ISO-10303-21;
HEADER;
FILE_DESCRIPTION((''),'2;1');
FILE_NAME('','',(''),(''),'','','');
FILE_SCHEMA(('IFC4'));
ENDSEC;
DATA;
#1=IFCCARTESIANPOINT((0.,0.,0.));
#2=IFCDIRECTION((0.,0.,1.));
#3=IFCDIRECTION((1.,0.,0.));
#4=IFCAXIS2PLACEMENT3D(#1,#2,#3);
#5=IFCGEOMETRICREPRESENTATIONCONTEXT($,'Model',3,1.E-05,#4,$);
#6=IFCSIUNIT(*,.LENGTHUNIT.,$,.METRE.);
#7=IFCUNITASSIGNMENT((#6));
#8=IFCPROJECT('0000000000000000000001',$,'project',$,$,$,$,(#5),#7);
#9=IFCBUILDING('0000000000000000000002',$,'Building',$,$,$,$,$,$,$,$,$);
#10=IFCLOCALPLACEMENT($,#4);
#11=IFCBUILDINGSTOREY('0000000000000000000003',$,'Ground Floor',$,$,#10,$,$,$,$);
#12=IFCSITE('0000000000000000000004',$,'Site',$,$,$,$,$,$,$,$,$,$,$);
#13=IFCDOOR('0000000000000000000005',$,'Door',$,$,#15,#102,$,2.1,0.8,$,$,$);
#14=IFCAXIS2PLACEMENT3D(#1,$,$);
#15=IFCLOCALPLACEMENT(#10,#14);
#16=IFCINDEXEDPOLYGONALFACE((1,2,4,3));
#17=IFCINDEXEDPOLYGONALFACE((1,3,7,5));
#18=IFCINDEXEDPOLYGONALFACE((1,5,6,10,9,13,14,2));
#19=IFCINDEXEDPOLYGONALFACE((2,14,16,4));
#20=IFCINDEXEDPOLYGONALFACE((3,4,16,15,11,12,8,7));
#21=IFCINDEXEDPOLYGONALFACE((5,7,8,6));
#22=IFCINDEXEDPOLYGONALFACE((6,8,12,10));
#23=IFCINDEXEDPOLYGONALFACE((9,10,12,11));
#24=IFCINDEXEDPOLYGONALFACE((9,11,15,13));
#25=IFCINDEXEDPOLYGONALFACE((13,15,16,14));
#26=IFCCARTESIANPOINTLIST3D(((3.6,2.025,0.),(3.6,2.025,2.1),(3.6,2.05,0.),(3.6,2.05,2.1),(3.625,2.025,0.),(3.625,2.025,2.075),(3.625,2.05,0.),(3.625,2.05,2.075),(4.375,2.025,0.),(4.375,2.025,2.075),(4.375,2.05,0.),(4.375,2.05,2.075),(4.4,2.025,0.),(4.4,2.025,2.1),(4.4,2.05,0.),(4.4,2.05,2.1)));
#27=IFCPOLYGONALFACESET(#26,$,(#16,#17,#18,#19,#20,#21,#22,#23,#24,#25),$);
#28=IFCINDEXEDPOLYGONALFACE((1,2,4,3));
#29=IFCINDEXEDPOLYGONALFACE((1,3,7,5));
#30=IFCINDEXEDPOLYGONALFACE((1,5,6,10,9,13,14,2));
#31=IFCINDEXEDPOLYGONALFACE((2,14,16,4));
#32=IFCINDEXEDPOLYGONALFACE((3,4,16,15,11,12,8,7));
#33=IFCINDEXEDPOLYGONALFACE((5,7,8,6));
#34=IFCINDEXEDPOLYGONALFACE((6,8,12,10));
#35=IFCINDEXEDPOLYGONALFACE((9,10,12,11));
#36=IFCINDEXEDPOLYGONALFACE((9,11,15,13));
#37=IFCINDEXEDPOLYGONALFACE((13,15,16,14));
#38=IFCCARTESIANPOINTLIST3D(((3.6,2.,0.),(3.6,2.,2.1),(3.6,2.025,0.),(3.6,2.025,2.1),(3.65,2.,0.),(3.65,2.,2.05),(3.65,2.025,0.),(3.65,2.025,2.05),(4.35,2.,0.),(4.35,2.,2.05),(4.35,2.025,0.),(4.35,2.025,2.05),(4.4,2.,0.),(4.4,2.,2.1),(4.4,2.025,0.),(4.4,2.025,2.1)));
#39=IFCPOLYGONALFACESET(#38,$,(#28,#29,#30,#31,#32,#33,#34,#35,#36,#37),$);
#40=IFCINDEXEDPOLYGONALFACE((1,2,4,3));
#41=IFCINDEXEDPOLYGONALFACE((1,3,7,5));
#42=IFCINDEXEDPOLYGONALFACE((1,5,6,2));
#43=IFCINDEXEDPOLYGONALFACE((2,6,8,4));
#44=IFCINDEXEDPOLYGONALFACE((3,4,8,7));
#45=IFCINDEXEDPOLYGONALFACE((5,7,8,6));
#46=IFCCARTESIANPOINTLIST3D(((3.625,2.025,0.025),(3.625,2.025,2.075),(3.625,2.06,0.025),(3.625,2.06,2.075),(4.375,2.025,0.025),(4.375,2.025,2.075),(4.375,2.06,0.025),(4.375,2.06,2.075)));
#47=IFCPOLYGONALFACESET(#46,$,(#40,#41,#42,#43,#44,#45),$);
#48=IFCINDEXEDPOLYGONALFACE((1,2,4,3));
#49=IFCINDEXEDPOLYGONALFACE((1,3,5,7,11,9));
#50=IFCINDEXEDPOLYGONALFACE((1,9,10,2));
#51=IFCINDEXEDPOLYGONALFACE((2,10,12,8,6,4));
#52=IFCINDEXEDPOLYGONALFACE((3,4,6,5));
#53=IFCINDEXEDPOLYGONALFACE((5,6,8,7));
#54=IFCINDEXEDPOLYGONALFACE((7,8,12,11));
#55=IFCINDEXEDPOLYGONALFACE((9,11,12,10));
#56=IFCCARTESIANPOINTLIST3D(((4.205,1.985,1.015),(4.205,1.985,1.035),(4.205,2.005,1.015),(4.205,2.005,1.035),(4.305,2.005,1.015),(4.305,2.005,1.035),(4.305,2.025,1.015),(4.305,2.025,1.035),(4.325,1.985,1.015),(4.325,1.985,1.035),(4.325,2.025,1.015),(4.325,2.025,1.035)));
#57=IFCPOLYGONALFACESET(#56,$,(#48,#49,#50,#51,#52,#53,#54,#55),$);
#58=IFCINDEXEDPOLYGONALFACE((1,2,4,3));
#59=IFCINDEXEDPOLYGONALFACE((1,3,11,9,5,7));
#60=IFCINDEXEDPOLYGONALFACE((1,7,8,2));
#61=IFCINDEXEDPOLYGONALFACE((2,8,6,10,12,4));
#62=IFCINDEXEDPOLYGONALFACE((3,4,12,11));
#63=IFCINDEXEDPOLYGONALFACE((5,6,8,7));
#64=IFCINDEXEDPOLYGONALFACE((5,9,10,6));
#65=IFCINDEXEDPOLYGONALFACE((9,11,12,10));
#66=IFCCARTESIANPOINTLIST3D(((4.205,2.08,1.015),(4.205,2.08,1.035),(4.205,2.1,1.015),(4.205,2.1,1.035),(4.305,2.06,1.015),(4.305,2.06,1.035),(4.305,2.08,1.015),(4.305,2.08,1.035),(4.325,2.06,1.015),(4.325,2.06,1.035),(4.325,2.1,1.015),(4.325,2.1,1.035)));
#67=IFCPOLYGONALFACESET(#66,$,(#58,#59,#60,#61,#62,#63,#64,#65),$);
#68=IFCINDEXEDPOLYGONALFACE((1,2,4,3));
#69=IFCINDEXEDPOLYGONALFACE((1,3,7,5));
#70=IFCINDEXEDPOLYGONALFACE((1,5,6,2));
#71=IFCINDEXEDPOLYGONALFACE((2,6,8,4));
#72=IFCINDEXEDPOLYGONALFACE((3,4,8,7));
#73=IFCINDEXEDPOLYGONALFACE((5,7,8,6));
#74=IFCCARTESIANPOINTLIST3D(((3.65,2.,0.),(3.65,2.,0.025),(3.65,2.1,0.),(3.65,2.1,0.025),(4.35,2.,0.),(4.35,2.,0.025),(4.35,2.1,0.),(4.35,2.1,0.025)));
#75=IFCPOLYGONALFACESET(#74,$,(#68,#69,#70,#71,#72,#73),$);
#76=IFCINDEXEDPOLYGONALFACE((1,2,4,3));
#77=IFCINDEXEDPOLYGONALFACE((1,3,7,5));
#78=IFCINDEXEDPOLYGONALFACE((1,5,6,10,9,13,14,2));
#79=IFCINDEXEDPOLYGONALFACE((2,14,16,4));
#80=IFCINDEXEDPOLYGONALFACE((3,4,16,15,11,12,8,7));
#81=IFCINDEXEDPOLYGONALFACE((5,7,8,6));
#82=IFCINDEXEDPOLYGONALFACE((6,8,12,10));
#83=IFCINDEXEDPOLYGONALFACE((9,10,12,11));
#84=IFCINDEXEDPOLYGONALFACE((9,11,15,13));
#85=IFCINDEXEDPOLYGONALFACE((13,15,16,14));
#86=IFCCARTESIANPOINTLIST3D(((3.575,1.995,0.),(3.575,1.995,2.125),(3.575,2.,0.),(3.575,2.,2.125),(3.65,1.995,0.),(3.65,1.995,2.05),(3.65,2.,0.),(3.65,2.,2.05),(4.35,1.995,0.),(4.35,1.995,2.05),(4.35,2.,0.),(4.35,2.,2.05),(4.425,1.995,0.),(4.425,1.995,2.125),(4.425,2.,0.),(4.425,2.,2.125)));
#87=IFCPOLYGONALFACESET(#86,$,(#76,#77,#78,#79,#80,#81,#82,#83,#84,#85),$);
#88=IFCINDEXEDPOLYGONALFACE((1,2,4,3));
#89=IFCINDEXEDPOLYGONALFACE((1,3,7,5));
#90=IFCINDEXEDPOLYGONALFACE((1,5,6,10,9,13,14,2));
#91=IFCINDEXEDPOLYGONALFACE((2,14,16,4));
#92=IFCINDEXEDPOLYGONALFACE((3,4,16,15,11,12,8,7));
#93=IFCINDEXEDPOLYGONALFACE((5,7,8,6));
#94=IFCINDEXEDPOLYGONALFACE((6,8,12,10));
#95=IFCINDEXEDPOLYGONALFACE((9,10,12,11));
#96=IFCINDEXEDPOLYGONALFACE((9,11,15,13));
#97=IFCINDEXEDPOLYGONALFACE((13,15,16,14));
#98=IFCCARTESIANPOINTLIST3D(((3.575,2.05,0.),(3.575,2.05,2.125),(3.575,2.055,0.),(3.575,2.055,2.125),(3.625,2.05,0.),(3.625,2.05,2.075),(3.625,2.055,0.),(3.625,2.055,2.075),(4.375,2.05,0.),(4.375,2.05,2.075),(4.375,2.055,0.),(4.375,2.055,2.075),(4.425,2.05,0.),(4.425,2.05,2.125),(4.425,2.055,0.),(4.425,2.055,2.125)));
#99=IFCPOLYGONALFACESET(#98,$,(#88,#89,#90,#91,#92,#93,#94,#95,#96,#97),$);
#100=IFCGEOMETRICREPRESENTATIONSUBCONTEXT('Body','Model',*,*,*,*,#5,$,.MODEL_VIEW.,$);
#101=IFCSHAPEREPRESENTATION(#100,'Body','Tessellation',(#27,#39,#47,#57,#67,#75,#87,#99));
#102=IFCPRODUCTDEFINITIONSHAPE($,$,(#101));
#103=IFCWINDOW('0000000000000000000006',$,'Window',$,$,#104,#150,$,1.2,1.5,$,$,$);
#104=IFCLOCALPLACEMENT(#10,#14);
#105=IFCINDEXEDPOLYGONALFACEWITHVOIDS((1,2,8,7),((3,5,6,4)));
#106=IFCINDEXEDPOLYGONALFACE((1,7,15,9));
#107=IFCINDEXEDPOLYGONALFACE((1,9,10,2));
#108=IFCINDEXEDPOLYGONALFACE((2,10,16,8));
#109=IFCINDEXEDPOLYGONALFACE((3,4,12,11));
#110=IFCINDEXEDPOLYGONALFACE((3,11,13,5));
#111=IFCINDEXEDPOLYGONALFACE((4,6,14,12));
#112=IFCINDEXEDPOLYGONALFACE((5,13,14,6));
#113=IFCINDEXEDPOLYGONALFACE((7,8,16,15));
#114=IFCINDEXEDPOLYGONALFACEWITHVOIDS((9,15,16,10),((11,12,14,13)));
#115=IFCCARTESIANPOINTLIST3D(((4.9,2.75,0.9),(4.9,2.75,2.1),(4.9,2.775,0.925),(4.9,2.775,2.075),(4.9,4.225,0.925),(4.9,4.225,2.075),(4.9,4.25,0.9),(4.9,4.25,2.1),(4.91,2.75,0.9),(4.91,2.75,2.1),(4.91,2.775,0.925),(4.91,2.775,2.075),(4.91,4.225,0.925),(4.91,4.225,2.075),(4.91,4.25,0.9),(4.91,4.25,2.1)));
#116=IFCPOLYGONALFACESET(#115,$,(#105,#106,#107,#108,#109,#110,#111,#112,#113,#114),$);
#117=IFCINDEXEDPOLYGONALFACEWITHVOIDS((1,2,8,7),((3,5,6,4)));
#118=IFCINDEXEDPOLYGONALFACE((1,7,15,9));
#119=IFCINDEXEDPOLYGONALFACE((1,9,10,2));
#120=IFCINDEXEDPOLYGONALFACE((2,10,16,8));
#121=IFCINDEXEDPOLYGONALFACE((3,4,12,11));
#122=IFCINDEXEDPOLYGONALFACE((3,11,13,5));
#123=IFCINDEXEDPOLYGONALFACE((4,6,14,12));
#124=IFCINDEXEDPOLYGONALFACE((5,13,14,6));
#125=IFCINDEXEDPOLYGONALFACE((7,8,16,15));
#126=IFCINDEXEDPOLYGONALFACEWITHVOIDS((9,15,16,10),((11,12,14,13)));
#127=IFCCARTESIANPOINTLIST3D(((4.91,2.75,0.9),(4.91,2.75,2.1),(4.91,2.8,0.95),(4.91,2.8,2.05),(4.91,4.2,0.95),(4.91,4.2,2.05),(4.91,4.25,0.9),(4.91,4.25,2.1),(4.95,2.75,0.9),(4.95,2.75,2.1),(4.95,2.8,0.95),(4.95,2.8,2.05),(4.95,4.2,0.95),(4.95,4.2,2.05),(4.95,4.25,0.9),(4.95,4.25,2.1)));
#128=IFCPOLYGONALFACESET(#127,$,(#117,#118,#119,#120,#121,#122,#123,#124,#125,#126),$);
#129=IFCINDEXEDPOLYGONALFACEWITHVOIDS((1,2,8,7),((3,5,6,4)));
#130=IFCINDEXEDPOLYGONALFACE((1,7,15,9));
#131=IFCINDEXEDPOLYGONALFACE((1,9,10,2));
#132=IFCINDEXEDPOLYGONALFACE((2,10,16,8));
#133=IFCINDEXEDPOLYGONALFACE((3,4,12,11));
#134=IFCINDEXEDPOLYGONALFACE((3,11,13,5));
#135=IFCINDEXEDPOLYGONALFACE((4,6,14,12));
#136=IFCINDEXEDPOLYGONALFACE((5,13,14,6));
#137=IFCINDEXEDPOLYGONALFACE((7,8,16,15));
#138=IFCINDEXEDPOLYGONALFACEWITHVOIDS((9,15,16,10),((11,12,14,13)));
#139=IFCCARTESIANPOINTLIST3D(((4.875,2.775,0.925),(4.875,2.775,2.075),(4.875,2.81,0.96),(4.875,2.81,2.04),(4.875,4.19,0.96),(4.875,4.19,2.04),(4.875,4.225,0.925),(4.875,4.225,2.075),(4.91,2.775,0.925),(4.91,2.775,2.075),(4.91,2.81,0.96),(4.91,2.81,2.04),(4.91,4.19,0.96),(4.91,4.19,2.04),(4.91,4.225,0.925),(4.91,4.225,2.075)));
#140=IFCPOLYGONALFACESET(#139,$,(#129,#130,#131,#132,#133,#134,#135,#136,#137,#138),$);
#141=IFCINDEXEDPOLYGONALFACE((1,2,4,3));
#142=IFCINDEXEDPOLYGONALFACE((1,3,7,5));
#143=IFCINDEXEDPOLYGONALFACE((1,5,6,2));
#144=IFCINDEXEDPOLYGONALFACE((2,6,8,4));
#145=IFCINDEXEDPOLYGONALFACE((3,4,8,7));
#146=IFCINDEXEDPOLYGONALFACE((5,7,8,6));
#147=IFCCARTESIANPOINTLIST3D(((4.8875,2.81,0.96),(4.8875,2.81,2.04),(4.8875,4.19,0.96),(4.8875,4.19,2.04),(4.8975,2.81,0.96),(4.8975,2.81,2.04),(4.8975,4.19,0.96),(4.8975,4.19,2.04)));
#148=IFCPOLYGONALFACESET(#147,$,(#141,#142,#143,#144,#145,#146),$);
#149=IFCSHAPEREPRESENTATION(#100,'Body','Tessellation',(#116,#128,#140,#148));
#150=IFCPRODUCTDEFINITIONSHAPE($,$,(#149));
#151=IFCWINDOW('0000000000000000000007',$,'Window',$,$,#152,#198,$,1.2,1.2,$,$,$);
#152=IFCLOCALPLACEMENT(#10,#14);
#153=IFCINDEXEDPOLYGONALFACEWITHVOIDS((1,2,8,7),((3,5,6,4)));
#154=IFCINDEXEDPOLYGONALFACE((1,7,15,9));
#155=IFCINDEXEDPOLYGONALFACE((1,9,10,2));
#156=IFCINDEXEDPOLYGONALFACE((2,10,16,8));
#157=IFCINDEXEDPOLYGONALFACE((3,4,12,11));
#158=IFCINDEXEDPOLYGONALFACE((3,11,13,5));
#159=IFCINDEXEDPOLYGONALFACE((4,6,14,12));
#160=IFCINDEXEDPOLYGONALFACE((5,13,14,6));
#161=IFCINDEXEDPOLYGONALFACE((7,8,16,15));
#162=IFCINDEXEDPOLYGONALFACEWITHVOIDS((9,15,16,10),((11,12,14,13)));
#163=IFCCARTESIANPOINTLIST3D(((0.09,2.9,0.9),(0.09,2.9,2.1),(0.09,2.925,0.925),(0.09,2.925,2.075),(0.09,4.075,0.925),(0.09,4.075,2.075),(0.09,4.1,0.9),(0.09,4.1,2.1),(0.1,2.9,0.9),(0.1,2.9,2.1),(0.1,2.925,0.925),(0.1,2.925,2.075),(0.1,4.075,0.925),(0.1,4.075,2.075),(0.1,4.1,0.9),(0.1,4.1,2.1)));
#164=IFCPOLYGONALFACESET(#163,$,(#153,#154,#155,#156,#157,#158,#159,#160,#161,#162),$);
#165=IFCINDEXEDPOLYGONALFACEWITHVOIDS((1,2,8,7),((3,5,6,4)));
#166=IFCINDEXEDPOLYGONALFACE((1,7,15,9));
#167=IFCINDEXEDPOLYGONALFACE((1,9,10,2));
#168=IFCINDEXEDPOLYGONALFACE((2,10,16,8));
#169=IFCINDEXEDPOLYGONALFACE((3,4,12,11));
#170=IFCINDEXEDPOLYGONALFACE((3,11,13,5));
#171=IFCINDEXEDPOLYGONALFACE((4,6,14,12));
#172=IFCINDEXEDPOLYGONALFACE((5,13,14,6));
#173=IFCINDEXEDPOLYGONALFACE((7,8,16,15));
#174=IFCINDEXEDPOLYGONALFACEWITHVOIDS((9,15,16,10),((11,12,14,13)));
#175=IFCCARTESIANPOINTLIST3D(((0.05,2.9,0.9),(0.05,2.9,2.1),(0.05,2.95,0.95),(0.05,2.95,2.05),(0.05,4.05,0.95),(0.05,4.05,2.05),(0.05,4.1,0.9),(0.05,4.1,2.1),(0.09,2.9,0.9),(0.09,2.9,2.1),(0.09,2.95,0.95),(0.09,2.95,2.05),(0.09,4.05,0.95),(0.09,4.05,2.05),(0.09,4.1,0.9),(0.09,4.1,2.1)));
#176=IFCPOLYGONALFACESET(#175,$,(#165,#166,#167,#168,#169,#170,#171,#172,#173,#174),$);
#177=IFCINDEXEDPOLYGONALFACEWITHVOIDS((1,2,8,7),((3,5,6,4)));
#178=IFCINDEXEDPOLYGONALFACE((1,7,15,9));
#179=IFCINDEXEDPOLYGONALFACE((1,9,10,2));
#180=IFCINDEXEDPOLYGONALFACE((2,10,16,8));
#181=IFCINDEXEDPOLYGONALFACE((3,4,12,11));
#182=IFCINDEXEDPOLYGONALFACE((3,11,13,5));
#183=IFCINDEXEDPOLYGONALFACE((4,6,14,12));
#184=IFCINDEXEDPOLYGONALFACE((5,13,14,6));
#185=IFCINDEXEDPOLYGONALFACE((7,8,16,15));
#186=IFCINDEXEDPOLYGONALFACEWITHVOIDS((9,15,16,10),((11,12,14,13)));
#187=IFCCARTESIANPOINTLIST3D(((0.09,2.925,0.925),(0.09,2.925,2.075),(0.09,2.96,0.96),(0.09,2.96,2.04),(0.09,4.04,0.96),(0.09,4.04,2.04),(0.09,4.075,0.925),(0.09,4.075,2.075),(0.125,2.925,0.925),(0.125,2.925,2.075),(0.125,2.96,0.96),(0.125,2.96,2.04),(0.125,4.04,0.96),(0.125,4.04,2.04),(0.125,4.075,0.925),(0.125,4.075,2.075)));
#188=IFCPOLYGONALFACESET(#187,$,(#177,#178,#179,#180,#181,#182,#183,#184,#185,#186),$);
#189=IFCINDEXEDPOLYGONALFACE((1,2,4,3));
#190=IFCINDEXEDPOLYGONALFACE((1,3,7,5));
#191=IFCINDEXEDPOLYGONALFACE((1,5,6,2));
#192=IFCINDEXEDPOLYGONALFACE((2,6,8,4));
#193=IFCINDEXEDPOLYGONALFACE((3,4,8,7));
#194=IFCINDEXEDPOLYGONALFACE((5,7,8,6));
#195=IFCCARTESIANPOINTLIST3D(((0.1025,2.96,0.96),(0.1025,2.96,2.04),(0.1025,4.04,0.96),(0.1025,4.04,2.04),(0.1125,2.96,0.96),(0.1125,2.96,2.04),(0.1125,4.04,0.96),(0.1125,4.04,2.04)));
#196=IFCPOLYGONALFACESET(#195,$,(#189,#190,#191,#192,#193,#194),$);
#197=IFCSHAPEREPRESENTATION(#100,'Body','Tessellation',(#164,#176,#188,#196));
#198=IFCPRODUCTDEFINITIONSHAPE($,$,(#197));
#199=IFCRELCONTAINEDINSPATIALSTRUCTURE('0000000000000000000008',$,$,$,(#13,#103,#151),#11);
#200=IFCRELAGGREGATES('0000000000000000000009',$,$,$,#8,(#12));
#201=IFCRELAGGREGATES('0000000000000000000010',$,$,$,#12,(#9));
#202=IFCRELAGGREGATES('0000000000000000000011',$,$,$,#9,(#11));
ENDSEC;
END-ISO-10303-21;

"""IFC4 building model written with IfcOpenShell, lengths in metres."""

from ifc_helpers import new_model, si_unit, frame, origin_with_axes, place, context, subcontext, project, spatial, line, indexed_curve, outline, extrude, element, save


model = new_model("IFC4")

# Units and contexts
model_context = context("Model", 3, precision=1e-05, world=origin_with_axes())
body_context = subcontext(model_context, "Body", "Model", "MODEL_VIEW")
ifc_project = project(units=[si_unit("LENGTHUNIT", "METRE")], contexts=[model_context])

# Site, building, storey
site = spatial("IfcSite", under=ifc_project, Name="Site")
building = spatial("IfcBuilding", under=site, Name="Building")
storey_placement = place(None, origin_with_axes())
storey = spatial("IfcBuildingStorey", under=building, at=storey_placement, Name="Ground Floor")

# Door
door_1_placement = place(storey_placement, frame((3.6, 2.0, 0.0), z_axis=(0.0, 0.0, 1.0), x_axis=(1.0, 0.0, 0.0)))
element("IfcDoor", 1, at=door_1_placement, inside=storey, Name="Door", OverallHeight=2.1, OverallWidth=0.8, context=body_context, shape_type="SweptSolid", body=[
    extrude(outline(indexed_curve([(0.0, 0.0), (0.0, 2.1), (0.8, 2.1), (0.8, 0.0), (0.775, 0.0), (0.775, 2.075), (0.025, 2.075), (0.025, 0.0)], segments=[line(1, 2, 3, 4, 5, 6, 7, 8, 1)])), frame((0.0, 0.025, 0.0), z_axis=(0.0, -1.0, 0.0), x_axis=(1.0, 0.0, 0.0)), (0.0, 0.0, -1.0), 0.025),
    extrude(outline(indexed_curve([(0.0, 0.0), (0.0, 2.1), (0.8, 2.1), (0.8, 0.0), (0.75, 0.0), (0.75, 2.05), (0.05, 2.05), (0.05, 0.0)], segments=[line(1, 2, 3, 4, 5, 6, 7, 8, 1)])), frame((0.0, 0.0, 0.0), z_axis=(0.0, -1.0, 0.0), x_axis=(1.0, 0.0, 0.0)), (0.0, 0.0, -1.0), 0.025),
    extrude(outline(indexed_curve([(0.0, 0.0), (0.75, 0.0), (0.75, 0.035), (0.0, 0.035)], segments=[line(1, 2, 3, 4, 1)])), frame((0.025, 0.025, 0.025), z_axis=(0.0, 0.0, 1.0), x_axis=(1.0, 0.0, 0.0)), (0.0, 0.0, 1.0), 2.05),
    extrude(outline(indexed_curve([(0.0, 0.0), (0.0, -0.04), (-0.12, -0.04), (-0.12, -0.02), (-0.02, -0.02), (-0.02, 0.0)], segments=[line(1, 2, 3, 4, 5, 6, 1)])), frame((0.725, 0.025, 1.015), z_axis=(0.0, 0.0, 1.0), x_axis=(1.0, 0.0, 0.0)), (0.0, 0.0, 1.0), 0.02),
    extrude(outline(indexed_curve([(0.0, 0.0), (0.0, 0.04), (-0.12, 0.04), (-0.12, 0.02), (-0.02, 0.02), (-0.02, 0.0)], segments=[line(1, 2, 3, 4, 5, 6, 1)])), frame((0.725, 0.06, 1.015), z_axis=(0.0, 0.0, 1.0), x_axis=(1.0, 0.0, 0.0)), (0.0, 0.0, 1.0), 0.02),
    extrude(outline(indexed_curve([(0.0, 0.0), (0.7, 0.0), (0.7, 0.1), (0.0, 0.1)], segments=[line(1, 2, 3, 4, 1)])), frame((0.05, 0.0, 0.0), z_axis=(0.0, 0.0, 1.0), x_axis=(1.0, 0.0, 0.0)), (0.0, 0.0, 1.0), 0.025),
    extrude(outline(indexed_curve([(0.0, 0.0), (0.0, 2.125), (0.85, 2.125), (0.85, 0.0), (0.775, 0.0), (0.775, 2.05), (0.075, 2.05), (0.075, 0.0)], segments=[line(1, 2, 3, 4, 5, 6, 7, 8, 1)])), frame((-0.025, -0.005, 0.0), z_axis=(0.0, -1.0, 0.0), x_axis=(1.0, 0.0, 0.0)), (0.0, 0.0, -1.0), 0.005),
    extrude(outline(indexed_curve([(0.0, 0.0), (0.0, 2.125), (0.85, 2.125), (0.85, 0.0), (0.8, 0.0), (0.8, 2.075), (0.05, 2.075), (0.05, 0.0)], segments=[line(1, 2, 3, 4, 5, 6, 7, 8, 1)])), frame((-0.025, 0.05, 0.0), z_axis=(0.0, -1.0, 0.0), x_axis=(1.0, 0.0, 0.0)), (0.0, 0.0, -1.0), 0.005),
])

# Windows
window_1_placement = place(storey_placement, frame((5.0, 2.75, 0.9), z_axis=(0.0, 0.0, 1.0), x_axis=(0.0, 1.0, 0.0)))
element("IfcWindow", 2, at=window_1_placement, inside=storey, Name="Window", OverallHeight=1.2, OverallWidth=1.5, context=body_context, shape_type="SweptSolid", body=[
    extrude(outline(indexed_curve([(0.0, 0.0), (1.5, 0.0), (1.5, 1.2), (0.0, 1.2)], segments=[line(1, 2, 3, 4, 1)]), holes=[indexed_curve([(0.025, 0.025), (1.475, 0.025), (1.475, 1.175), (0.025, 1.175)], segments=[line(1, 2, 3, 4, 1)])]), frame((0.0, 0.09, 0.0), z_axis=(0.0, -1.0, 0.0), x_axis=(1.0, 0.0, 0.0)), (0.0, 0.0, -1.0), 0.01),
    extrude(outline(indexed_curve([(0.0, 0.0), (1.5, 0.0), (1.5, 1.2), (0.0, 1.2)], segments=[line(1, 2, 3, 4, 1)]), holes=[indexed_curve([(0.05, 0.05), (1.45, 0.05), (1.45, 1.15), (0.05, 1.15)], segments=[line(1, 2, 3, 4, 1)])]), frame((0.0, 0.05, 0.0), z_axis=(0.0, -1.0, 0.0), x_axis=(1.0, 0.0, 0.0)), (0.0, 0.0, -1.0), 0.04),
    extrude(outline(indexed_curve([(0.0, 0.0), (1.45, 0.0), (1.45, 1.15), (0.0, 1.15)], segments=[line(1, 2, 3, 4, 1)]), holes=[indexed_curve([(0.035, 0.035), (1.415, 0.035), (1.415, 1.115), (0.035, 1.115)], segments=[line(1, 2, 3, 4, 1)])]), frame((0.025, 0.09, 0.025), z_axis=(0.0, -1.0, 0.0), x_axis=(1.0, 0.0, 0.0)), (0.0, 0.0, -1.0), 0.035),
    extrude(outline(indexed_curve([(0.035, 0.035), (1.415, 0.035), (1.415, 1.115), (0.035, 1.115)], segments=[line(1, 2, 3, 4, 1)])), frame((0.025, 0.1025, 0.025), z_axis=(0.0, -1.0, 0.0), x_axis=(1.0, 0.0, 0.0)), (0.0, 0.0, -1.0), 0.01),
])
window_2_placement = place(storey_placement, frame((0.0, 4.1, 0.9), z_axis=(0.0, 0.0, 1.0), x_axis=(0.0, -1.0, 0.0)))
element("IfcWindow", 3, at=window_2_placement, inside=storey, Name="Window", OverallHeight=1.2, OverallWidth=1.2, context=body_context, shape_type="SweptSolid", body=[
    extrude(outline(indexed_curve([(0.0, 0.0), (1.2, 0.0), (1.2, 1.2), (0.0, 1.2)], segments=[line(1, 2, 3, 4, 1)]), holes=[indexed_curve([(0.025, 0.025), (1.175, 0.025), (1.175, 1.175), (0.025, 1.175)], segments=[line(1, 2, 3, 4, 1)])]), frame((0.0, 0.09, 0.0), z_axis=(0.0, -1.0, 0.0), x_axis=(1.0, 0.0, 0.0)), (0.0, 0.0, -1.0), 0.01),
    extrude(outline(indexed_curve([(0.0, 0.0), (1.2, 0.0), (1.2, 1.2), (0.0, 1.2)], segments=[line(1, 2, 3, 4, 1)]), holes=[indexed_curve([(0.05, 0.05), (1.15, 0.05), (1.15, 1.15), (0.05, 1.15)], segments=[line(1, 2, 3, 4, 1)])]), frame((0.0, 0.05, 0.0), z_axis=(0.0, -1.0, 0.0), x_axis=(1.0, 0.0, 0.0)), (0.0, 0.0, -1.0), 0.04),
    extrude(outline(indexed_curve([(0.0, 0.0), (1.15, 0.0), (1.15, 1.15), (0.0, 1.15)], segments=[line(1, 2, 3, 4, 1)]), holes=[indexed_curve([(0.035, 0.035), (1.115, 0.035), (1.115, 1.115), (0.035, 1.115)], segments=[line(1, 2, 3, 4, 1)])]), frame((0.025, 0.09, 0.025), z_axis=(0.0, -1.0, 0.0), x_axis=(1.0, 0.0, 0.0)), (0.0, 0.0, -1.0), 0.035),
    extrude(outline(indexed_curve([(0.035, 0.035), (1.115, 0.035), (1.115, 1.115), (0.035, 1.115)], segments=[line(1, 2, 3, 4, 1)])), frame((0.025, 0.1025, 0.025), z_axis=(0.0, -1.0, 0.0), x_axis=(1.0, 0.0, 0.0)), (0.0, 0.0, -1.0), 0.01),
])

save(model, "model.ifc")
